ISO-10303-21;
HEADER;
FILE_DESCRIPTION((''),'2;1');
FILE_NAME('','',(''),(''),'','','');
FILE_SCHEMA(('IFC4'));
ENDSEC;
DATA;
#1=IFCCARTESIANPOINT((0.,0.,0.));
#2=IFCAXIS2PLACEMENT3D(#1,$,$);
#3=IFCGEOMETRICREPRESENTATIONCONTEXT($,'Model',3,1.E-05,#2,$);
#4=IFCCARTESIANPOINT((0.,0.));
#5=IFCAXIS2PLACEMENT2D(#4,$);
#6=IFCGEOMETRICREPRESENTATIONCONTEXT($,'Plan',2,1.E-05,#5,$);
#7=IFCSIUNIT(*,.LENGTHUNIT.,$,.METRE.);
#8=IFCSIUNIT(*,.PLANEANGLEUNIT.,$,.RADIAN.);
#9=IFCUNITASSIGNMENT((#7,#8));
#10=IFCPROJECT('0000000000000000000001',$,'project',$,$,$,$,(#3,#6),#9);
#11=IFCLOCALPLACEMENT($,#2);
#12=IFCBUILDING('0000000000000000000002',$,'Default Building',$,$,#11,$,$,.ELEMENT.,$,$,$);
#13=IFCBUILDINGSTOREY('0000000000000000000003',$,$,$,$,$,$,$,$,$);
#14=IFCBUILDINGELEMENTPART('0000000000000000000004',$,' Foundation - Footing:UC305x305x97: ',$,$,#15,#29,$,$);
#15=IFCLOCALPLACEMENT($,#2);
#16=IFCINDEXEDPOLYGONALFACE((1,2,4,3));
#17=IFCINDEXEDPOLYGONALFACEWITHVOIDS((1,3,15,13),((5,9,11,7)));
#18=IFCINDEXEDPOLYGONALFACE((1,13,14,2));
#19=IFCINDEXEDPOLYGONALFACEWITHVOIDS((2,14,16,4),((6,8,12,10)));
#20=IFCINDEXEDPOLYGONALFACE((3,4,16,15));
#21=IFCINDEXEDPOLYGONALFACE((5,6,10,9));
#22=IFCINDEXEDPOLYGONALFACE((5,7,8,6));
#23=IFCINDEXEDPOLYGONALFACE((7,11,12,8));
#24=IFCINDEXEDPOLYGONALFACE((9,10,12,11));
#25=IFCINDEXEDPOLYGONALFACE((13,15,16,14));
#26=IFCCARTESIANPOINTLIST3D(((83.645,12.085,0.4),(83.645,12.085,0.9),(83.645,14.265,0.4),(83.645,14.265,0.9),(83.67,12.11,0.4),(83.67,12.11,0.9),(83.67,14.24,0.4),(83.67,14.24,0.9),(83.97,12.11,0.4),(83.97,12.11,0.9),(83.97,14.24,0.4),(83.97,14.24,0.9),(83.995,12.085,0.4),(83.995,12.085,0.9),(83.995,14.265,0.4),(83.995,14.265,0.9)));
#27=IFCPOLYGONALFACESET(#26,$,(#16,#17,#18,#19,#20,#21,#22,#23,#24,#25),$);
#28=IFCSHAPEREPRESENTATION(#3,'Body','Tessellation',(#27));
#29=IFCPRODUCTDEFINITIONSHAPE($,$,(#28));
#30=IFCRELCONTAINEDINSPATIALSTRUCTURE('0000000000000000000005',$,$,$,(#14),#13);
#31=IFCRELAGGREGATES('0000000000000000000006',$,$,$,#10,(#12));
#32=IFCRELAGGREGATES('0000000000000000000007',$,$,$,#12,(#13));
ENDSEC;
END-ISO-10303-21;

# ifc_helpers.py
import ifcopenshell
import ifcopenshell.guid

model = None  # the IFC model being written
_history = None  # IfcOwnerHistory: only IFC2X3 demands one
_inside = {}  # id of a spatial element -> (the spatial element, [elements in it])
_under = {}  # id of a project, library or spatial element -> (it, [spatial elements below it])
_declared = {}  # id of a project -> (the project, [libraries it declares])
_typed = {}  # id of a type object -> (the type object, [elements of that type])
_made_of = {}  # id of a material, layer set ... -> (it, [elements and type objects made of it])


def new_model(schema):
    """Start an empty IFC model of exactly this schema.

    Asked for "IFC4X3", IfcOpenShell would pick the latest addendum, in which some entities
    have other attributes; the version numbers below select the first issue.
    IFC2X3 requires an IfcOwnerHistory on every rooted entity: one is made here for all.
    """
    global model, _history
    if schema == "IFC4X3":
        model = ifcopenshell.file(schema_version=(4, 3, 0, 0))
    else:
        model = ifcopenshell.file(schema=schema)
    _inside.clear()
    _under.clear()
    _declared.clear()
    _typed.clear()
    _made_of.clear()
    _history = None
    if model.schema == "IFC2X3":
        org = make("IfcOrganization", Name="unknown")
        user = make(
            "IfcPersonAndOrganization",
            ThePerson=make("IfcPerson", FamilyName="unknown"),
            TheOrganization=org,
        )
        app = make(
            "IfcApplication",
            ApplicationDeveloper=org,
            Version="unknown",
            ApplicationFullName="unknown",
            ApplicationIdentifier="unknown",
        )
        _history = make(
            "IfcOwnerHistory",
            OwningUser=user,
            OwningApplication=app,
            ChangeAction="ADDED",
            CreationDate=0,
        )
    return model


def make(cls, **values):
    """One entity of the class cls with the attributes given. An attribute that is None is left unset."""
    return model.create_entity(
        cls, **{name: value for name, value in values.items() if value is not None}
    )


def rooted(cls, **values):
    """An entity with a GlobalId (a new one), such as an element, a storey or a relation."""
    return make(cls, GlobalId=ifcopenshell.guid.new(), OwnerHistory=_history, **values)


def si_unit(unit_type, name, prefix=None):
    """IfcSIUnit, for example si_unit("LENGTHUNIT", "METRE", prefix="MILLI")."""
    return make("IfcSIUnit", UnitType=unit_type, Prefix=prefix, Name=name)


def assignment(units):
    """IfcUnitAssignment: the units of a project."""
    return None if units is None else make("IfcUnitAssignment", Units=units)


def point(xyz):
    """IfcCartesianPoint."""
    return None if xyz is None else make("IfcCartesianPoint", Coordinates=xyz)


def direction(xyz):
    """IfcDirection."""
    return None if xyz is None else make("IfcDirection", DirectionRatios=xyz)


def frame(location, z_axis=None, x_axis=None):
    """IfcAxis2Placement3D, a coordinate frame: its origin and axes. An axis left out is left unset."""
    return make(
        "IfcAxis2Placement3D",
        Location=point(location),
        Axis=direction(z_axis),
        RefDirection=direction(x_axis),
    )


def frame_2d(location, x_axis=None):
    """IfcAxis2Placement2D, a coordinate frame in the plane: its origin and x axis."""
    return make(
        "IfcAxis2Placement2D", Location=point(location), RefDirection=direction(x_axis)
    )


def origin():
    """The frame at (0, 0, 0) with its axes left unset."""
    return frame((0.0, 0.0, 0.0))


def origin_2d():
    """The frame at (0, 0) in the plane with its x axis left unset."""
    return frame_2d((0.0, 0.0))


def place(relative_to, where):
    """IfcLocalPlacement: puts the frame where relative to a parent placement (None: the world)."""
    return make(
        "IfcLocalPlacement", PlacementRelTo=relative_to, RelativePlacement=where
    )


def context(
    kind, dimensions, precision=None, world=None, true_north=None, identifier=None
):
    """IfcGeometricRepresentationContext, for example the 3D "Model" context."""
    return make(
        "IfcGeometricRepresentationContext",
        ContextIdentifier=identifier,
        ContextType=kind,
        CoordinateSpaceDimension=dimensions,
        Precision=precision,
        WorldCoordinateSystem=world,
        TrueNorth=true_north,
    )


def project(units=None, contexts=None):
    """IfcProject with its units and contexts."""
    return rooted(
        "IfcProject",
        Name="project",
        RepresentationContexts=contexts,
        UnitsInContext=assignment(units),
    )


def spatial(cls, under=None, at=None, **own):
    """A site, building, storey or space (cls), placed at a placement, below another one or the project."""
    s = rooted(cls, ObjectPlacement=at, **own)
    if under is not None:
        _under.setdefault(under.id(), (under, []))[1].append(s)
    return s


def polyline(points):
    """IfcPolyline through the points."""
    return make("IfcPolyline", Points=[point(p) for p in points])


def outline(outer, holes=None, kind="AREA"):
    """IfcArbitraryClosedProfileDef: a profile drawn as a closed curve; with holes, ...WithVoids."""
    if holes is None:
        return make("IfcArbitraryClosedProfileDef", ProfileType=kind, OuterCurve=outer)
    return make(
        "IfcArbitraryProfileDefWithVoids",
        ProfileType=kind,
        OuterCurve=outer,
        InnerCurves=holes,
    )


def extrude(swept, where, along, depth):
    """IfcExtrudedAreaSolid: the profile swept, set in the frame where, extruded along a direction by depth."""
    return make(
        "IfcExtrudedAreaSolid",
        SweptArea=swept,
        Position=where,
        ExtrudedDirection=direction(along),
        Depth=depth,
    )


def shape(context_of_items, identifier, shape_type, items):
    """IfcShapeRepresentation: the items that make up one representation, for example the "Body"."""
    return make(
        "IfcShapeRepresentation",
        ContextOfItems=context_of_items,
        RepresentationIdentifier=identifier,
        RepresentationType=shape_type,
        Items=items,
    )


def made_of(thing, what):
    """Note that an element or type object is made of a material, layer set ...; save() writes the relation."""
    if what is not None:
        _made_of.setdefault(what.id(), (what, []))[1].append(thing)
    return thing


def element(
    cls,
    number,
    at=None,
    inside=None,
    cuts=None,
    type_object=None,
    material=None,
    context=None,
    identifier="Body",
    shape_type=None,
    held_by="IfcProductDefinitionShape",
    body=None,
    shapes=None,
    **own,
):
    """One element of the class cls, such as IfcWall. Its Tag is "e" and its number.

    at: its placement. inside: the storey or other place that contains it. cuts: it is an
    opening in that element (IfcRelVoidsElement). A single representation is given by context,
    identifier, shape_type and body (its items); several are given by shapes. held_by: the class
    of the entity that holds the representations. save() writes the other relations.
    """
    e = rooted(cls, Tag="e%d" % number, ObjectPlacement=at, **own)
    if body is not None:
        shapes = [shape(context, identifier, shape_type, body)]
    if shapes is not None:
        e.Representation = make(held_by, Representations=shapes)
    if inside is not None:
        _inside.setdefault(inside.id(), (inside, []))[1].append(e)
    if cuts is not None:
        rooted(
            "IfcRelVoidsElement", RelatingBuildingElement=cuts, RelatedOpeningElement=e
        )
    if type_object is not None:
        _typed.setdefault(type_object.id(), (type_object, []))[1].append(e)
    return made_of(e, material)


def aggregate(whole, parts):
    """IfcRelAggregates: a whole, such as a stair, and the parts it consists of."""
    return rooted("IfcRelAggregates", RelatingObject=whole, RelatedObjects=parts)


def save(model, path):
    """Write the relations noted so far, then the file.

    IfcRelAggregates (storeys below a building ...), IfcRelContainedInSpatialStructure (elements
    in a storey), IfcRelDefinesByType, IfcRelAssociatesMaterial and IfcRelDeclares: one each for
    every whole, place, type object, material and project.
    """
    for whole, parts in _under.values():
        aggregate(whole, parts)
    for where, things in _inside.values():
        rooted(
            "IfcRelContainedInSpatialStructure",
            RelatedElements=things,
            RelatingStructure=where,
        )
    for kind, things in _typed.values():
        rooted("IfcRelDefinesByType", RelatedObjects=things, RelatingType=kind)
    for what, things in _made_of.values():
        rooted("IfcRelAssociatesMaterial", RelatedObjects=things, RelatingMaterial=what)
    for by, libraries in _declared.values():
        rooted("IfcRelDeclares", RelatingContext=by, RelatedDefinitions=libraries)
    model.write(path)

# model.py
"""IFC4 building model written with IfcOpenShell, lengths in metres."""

from ifc_helpers import new_model, si_unit, origin, origin_2d, place, context, project, spatial, polyline, outline, extrude, element, save


model = new_model("IFC4")

# Units and contexts
model_context = context("Model", 3, precision=1e-05, world=origin())
plan_context = context("Plan", 2, precision=1e-05, world=origin_2d())
ifc_project = project(units=[si_unit("LENGTHUNIT", "METRE"), si_unit("PLANEANGLEUNIT", "RADIAN")], contexts=[model_context, plan_context])

# Building, storey
building_placement = place(None, origin())
building = spatial("IfcBuilding", under=ifc_project, at=building_placement, Name="Default Building", CompositionType="ELEMENT")
storey = spatial("IfcBuildingStorey", under=building)

# Building element part, opening
building_element_part_1 = element("IfcBuildingElementPart", 1, inside=storey, Name=" Foundation - Footing:UC305x305x97: ", context=model_context, shape_type="SweptSolid", body=[
    extrude(outline(polyline([(83.995, 12.085, 0.4), (83.645, 12.085, 0.4), (83.645, 14.265, 0.4), (83.995, 14.265, 0.4), (83.995, 12.085, 0.4)])), None, (0.0, 0.0, 1.0), 0.5),
])
element("IfcOpeningElement", 2, inside=storey, cuts=building_element_part_1, context=model_context, shape_type="SweptSolid", body=[
    extrude(outline(polyline([(83.97, 12.11, 0.4), (83.67, 12.11, 0.4), (83.67, 14.24, 0.4), (83.97, 14.24, 0.4), (83.97, 12.11, 0.4)])), None, (0.0, 0.0, 1.0), 0.5),
])

save(model, "model.ifc")
